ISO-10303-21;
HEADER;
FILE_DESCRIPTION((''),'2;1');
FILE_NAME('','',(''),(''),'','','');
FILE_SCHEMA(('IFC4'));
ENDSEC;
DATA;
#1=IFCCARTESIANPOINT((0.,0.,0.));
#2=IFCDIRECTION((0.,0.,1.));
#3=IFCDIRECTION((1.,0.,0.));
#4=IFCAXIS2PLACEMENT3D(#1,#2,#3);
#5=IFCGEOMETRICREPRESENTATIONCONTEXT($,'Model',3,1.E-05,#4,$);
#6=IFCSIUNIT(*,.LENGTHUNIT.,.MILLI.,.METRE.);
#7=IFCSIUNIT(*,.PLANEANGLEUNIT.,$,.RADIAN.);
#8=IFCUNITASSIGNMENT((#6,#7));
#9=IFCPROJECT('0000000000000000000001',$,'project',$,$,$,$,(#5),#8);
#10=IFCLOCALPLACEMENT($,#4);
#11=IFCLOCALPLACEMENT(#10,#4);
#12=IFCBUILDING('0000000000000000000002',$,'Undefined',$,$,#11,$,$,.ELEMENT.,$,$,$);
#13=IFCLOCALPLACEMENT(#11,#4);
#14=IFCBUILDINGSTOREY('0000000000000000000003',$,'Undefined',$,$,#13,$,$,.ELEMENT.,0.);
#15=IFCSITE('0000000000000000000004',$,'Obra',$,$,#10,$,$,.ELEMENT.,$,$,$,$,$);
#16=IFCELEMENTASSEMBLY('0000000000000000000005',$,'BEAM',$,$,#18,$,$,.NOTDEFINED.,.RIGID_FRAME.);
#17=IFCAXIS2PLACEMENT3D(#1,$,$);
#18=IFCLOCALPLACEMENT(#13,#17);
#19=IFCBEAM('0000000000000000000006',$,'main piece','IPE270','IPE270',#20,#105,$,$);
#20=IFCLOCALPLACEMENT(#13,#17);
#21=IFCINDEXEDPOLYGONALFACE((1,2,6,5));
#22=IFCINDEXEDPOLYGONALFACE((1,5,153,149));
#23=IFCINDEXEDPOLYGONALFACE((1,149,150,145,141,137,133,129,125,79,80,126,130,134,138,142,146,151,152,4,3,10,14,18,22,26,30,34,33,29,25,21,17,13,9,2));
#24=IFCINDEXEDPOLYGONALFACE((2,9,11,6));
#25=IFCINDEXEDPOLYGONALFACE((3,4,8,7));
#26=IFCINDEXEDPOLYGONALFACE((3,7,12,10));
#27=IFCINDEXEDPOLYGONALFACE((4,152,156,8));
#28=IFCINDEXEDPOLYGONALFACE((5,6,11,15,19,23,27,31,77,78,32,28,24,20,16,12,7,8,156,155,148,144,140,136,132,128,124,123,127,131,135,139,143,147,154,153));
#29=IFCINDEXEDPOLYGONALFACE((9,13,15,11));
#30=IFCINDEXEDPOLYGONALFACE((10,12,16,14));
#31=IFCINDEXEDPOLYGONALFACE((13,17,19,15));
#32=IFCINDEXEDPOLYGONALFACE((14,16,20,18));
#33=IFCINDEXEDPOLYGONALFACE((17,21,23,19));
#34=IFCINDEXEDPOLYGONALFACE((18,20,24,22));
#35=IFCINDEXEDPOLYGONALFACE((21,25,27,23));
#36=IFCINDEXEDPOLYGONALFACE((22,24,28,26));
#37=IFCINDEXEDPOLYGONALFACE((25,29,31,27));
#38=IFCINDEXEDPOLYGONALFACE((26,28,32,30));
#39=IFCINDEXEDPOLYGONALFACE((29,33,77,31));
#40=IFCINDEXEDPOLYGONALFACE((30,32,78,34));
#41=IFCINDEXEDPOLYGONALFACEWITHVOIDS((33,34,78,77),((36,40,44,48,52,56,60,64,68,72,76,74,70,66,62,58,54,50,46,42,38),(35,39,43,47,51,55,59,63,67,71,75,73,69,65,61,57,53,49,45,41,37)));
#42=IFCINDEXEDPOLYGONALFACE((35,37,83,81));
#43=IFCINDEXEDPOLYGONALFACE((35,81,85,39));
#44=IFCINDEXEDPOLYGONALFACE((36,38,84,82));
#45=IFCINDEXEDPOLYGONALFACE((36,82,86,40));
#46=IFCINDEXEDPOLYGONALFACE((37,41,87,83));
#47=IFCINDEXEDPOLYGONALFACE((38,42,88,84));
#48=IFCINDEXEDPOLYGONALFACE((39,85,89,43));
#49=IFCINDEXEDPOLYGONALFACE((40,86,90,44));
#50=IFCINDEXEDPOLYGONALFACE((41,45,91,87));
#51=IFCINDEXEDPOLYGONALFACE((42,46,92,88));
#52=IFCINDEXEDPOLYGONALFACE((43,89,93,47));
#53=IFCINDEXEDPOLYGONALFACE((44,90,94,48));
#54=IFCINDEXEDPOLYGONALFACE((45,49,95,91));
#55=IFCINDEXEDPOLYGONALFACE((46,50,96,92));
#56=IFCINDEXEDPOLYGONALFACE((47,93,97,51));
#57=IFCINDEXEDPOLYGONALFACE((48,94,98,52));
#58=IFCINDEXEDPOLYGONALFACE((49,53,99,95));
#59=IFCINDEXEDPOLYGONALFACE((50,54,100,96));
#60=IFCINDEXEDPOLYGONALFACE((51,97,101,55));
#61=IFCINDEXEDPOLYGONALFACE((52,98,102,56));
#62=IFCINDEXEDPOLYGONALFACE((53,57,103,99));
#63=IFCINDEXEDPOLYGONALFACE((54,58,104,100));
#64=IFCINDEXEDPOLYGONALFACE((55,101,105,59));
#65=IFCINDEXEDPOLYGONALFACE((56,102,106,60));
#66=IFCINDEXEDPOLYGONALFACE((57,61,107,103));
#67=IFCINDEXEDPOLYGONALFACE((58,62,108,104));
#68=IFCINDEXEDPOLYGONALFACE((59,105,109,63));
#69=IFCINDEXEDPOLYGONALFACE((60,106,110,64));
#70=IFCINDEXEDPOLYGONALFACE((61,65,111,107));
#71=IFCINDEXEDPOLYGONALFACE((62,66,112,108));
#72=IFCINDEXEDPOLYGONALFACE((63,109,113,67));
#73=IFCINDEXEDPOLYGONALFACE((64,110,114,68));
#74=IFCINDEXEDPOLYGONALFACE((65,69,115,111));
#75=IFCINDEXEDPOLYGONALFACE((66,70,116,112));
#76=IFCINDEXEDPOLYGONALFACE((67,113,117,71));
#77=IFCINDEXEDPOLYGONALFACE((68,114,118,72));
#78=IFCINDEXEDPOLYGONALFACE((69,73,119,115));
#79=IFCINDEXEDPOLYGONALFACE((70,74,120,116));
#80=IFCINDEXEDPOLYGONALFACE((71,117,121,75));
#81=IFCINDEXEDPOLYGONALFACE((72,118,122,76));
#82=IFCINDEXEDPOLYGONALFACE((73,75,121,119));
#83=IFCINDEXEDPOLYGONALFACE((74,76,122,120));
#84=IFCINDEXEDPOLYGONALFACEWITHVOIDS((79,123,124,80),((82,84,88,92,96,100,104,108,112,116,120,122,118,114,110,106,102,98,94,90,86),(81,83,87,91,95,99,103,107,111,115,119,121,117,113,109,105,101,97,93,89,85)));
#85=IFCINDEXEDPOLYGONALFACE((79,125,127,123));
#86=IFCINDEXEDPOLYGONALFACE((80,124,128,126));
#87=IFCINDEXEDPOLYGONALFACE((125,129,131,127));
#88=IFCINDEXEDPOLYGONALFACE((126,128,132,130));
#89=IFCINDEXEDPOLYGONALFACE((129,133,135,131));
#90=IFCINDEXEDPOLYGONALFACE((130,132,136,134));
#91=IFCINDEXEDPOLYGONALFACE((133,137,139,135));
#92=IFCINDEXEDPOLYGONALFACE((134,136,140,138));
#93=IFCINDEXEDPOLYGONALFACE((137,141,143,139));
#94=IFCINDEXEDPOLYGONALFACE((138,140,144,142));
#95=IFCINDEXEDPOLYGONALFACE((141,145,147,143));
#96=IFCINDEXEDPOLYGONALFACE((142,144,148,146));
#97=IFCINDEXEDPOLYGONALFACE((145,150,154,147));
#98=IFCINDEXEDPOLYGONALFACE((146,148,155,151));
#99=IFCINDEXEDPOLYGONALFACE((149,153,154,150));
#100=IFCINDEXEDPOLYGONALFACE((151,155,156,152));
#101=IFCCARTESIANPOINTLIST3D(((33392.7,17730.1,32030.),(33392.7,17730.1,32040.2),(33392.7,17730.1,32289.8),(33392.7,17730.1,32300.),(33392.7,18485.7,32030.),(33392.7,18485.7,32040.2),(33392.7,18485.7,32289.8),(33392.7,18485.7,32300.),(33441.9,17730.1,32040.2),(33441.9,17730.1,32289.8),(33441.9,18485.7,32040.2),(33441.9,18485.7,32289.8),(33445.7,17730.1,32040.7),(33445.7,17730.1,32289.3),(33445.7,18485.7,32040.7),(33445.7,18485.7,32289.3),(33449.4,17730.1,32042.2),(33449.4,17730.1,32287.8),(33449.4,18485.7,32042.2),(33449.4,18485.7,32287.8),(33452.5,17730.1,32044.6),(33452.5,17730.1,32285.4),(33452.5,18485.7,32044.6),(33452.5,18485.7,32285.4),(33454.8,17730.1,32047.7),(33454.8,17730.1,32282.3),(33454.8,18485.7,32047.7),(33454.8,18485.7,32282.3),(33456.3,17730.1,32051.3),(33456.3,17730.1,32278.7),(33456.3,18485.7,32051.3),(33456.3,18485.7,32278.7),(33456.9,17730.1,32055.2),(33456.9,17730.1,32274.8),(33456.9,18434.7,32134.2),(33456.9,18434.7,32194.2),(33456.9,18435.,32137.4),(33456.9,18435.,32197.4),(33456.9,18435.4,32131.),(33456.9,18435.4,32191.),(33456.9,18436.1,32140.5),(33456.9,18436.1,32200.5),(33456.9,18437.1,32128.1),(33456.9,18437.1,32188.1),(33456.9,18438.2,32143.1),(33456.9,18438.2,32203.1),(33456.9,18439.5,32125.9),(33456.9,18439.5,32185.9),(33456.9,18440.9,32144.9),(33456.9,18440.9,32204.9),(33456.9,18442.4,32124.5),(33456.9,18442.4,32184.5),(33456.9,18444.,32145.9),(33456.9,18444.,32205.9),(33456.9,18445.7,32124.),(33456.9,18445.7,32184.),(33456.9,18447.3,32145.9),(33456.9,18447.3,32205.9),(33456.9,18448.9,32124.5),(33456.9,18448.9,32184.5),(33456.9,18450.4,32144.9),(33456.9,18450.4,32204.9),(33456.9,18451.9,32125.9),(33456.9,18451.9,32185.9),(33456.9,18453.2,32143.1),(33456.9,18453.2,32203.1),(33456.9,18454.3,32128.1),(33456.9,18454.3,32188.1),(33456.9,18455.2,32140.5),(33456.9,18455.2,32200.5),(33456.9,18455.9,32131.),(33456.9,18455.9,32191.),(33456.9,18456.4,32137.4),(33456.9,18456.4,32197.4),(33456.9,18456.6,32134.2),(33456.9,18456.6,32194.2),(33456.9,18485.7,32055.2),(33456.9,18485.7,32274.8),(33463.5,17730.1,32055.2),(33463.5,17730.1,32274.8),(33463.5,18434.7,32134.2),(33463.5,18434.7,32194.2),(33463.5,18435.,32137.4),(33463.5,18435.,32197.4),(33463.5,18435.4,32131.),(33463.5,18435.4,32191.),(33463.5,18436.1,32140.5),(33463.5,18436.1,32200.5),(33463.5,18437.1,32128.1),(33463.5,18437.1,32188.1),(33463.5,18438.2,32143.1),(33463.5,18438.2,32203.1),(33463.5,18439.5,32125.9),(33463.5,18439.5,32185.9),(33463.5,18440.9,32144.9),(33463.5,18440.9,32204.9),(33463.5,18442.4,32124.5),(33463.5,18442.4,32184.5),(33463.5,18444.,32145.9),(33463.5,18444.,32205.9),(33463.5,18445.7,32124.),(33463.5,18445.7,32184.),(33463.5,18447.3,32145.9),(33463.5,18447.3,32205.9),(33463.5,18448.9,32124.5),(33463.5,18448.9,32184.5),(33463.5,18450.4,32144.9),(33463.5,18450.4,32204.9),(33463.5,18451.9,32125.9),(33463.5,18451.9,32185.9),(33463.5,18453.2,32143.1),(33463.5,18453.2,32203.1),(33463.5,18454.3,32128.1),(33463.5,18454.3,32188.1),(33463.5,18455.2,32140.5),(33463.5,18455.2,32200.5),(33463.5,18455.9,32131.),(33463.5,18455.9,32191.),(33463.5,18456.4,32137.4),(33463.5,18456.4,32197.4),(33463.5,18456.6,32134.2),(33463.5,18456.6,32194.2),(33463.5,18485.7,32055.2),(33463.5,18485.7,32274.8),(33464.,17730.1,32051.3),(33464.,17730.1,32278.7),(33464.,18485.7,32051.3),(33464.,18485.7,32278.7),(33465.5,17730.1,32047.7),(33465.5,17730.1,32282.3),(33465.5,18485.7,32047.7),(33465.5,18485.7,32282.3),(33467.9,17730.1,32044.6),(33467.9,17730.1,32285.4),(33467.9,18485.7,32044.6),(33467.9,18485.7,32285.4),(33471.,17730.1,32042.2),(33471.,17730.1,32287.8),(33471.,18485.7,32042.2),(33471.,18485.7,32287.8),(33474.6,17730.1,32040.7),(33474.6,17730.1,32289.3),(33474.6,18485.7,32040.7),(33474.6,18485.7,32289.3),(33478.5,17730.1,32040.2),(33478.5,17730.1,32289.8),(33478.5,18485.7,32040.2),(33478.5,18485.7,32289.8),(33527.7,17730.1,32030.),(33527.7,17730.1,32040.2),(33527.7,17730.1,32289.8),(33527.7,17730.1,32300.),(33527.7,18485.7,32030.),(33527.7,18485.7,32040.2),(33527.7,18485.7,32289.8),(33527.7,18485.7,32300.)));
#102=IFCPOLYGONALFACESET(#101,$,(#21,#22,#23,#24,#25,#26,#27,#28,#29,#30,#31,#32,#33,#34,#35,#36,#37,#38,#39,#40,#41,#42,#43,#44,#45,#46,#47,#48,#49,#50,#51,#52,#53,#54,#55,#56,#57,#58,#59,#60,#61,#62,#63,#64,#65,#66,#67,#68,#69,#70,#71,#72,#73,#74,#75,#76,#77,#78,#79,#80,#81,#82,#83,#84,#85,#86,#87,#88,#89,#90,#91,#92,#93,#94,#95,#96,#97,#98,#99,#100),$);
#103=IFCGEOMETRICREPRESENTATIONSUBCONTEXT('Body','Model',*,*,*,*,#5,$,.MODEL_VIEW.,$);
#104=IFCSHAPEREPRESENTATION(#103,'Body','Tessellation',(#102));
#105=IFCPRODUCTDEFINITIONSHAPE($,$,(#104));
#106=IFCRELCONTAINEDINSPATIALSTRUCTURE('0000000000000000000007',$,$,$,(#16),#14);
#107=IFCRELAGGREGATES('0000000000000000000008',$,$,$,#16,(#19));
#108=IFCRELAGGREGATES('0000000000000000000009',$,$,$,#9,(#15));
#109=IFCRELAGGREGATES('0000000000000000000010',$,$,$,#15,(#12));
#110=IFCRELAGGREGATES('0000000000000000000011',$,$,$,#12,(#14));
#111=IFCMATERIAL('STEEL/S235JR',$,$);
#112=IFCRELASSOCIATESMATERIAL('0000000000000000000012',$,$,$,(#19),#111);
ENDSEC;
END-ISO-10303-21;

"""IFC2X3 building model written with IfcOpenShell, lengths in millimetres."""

from ifc_helpers import new_model, si_unit, frame, origin_with_axes, origin_2d_with_axis, place, context, subcontext, project, spatial, rectangle, circle, i_section, extrude, clip, halfspace, source, transform, mapped, material, element, aggregate, save


model = new_model("IFC2X3")

# Units and contexts
model_context = context("Model", 3, precision=1e-05, world=origin_with_axes())
body_context = subcontext(model_context, "Body", "Model", "MODEL_VIEW")
ifc_project = project(units=[si_unit("LENGTHUNIT", "METRE", prefix="MILLI"), si_unit("PLANEANGLEUNIT", "RADIAN")], contexts=[model_context])

# Site, building, storey
site_placement = place(None, origin_with_axes())
site = spatial("IfcSite", under=ifc_project, at=site_placement, Name="Obra", CompositionType="ELEMENT")
building_placement = place(site_placement, origin_with_axes())
building = spatial("IfcBuilding", under=site, at=building_placement, Name="Undefined", CompositionType="ELEMENT")
storey_placement = place(building_placement, origin_with_axes())
storey = spatial("IfcBuildingStorey", under=building, at=storey_placement, Name="Undefined", CompositionType="ELEMENT", Elevation=0.0)

# Element assembly, beam, openings
assembly_1_placement = place(storey_placement, origin_with_axes())
assembly_1 = element("IfcElementAssembly", 1, at=assembly_1_placement, inside=storey, Name="BEAM", AssemblyPlace="NOTDEFINED", PredefinedType="RIGID_FRAME")
ifc_material_1 = material(Name="STEEL/S235JR")
beam_1_placement = place(assembly_1_placement, frame((33460.2, 17730.1, 32165.0), z_axis=(0.0, 0.0, 1.0), x_axis=(0.0, 1.0, 0.0)))
beam_1 = element("IfcBeam", 2, at=beam_1_placement, material=ifc_material_1, Name="main piece", Description="IPE270", ObjectType="IPE270", context=body_context, shape_type="Clipping", body=[
    clip(extrude(i_section(OverallWidth=135.0, OverallDepth=270.0, WebThickness=6.6, FlangeThickness=10.2, FilletRadius=15.0, at=origin_2d_with_axis()), frame((755.5, 0.0, 0.0), z_axis=(-1.0, 0.0, 0.0), x_axis=(0.0, -1.0, 0.0)), (0.0, 0.0, 1.0), 755.5), halfspace(frame((755.5, 0.0, -235.0), z_axis=(-1.0, 0.0, 0.0), x_axis=(0.0, 1.0, 0.0)), True)),
])
opening_1_placement = place(assembly_1_placement, frame((33460.2, 17730.1, 32165.0), z_axis=(0.0, 0.0, 1.0), x_axis=(0.0, 1.0, 0.0)))
element("IfcOpeningElement", 3, at=opening_1_placement, cuts=beam_1, ObjectType="Recess", context=body_context, shape_type="SweptSolid", body=[
    extrude(rectangle(XDim=26.2, YDim=76.2, at=origin_2d_with_axis()), frame((793.6, 68.5, -122.9), z_axis=(0.0, -1.0, 0.0), x_axis=(0.0, 0.0, -1.0)), (0.0, 0.0, 1.0), 137.0),
])
opening_2_placement = place(assembly_1_placement, frame((33460.2, 17730.1, 32165.0), z_axis=(0.0, 0.0, 1.0), x_axis=(0.0, 1.0, 0.0)))
element("IfcOpeningElement", 4, at=opening_2_placement, cuts=beam_1, ObjectType="Recess", context=body_context, shape_type="SweptSolid", body=[
    extrude(rectangle(XDim=26.2, YDim=76.2, at=origin_2d_with_axis()), frame((793.6, 68.5, 122.9), z_axis=(0.0, -1.0, 0.0), x_axis=(0.0, 0.0, -1.0)), (0.0, 0.0, 1.0), 137.0),
])
opening_3_placement = place(assembly_1_placement, frame((33460.2, 17730.1, 32165.0), z_axis=(0.0, 0.0, 1.0), x_axis=(0.0, 1.0, 0.0)))
element("IfcOpeningElement", 5, at=opening_3_placement, cuts=beam_1, ObjectType="Recess", context=body_context, shape_type="SweptSolid", body=[
    extrude(rectangle(XDim=26.2, YDim=76.2, at=origin_2d_with_axis()), frame((793.6, 68.5, -122.9), z_axis=(0.0, -1.0, 0.0), x_axis=(0.0, 0.0, -1.0)), (0.0, 0.0, 1.0), 137.0),
])
opening_4_placement = place(assembly_1_placement, frame((33460.2, 17730.1, 32165.0), z_axis=(0.0, 0.0, 1.0), x_axis=(0.0, 1.0, 0.0)))
element("IfcOpeningElement", 6, at=opening_4_placement, cuts=beam_1, ObjectType="Recess", context=body_context, shape_type="SweptSolid", body=[
    extrude(rectangle(XDim=26.2, YDim=76.2, at=origin_2d_with_axis()), frame((793.6, 68.5, 122.9), z_axis=(0.0, -1.0, 0.0), x_axis=(0.0, 0.0, -1.0)), (0.0, 0.0, 1.0), 137.0),
])
shared_shape_1 = source(origin_with_axes(), body_context, "Body", "SweptSolid", [
    extrude(circle(Radius=11.0, at=origin_2d_with_axis()), frame((0.0, -3.4, 0.0), z_axis=(0.0, 1.0, 0.0), x_axis=(1.0, 0.0, 0.0)), (0.0, 0.0, 1.0), 6.8),
])
opening_5_placement = place(assembly_1_placement, frame((33460.2, 18485.7, 32235.0), z_axis=(0.0, -1.0, 0.0), x_axis=(0.0, 0.0, -1.0)))
element("IfcOpeningElement", 7, at=opening_5_placement, cuts=beam_1, ObjectType="Opening", context=body_context, shape_type="MappedRepresentation", body=[
    mapped(shared_shape_1, transform((40.0, 0.0, 40.0))),
    mapped(shared_shape_1, transform((100.0, 0.0, 40.0))),
])

aggregate(assembly_1, [beam_1])

save(model, "model.ifc")
